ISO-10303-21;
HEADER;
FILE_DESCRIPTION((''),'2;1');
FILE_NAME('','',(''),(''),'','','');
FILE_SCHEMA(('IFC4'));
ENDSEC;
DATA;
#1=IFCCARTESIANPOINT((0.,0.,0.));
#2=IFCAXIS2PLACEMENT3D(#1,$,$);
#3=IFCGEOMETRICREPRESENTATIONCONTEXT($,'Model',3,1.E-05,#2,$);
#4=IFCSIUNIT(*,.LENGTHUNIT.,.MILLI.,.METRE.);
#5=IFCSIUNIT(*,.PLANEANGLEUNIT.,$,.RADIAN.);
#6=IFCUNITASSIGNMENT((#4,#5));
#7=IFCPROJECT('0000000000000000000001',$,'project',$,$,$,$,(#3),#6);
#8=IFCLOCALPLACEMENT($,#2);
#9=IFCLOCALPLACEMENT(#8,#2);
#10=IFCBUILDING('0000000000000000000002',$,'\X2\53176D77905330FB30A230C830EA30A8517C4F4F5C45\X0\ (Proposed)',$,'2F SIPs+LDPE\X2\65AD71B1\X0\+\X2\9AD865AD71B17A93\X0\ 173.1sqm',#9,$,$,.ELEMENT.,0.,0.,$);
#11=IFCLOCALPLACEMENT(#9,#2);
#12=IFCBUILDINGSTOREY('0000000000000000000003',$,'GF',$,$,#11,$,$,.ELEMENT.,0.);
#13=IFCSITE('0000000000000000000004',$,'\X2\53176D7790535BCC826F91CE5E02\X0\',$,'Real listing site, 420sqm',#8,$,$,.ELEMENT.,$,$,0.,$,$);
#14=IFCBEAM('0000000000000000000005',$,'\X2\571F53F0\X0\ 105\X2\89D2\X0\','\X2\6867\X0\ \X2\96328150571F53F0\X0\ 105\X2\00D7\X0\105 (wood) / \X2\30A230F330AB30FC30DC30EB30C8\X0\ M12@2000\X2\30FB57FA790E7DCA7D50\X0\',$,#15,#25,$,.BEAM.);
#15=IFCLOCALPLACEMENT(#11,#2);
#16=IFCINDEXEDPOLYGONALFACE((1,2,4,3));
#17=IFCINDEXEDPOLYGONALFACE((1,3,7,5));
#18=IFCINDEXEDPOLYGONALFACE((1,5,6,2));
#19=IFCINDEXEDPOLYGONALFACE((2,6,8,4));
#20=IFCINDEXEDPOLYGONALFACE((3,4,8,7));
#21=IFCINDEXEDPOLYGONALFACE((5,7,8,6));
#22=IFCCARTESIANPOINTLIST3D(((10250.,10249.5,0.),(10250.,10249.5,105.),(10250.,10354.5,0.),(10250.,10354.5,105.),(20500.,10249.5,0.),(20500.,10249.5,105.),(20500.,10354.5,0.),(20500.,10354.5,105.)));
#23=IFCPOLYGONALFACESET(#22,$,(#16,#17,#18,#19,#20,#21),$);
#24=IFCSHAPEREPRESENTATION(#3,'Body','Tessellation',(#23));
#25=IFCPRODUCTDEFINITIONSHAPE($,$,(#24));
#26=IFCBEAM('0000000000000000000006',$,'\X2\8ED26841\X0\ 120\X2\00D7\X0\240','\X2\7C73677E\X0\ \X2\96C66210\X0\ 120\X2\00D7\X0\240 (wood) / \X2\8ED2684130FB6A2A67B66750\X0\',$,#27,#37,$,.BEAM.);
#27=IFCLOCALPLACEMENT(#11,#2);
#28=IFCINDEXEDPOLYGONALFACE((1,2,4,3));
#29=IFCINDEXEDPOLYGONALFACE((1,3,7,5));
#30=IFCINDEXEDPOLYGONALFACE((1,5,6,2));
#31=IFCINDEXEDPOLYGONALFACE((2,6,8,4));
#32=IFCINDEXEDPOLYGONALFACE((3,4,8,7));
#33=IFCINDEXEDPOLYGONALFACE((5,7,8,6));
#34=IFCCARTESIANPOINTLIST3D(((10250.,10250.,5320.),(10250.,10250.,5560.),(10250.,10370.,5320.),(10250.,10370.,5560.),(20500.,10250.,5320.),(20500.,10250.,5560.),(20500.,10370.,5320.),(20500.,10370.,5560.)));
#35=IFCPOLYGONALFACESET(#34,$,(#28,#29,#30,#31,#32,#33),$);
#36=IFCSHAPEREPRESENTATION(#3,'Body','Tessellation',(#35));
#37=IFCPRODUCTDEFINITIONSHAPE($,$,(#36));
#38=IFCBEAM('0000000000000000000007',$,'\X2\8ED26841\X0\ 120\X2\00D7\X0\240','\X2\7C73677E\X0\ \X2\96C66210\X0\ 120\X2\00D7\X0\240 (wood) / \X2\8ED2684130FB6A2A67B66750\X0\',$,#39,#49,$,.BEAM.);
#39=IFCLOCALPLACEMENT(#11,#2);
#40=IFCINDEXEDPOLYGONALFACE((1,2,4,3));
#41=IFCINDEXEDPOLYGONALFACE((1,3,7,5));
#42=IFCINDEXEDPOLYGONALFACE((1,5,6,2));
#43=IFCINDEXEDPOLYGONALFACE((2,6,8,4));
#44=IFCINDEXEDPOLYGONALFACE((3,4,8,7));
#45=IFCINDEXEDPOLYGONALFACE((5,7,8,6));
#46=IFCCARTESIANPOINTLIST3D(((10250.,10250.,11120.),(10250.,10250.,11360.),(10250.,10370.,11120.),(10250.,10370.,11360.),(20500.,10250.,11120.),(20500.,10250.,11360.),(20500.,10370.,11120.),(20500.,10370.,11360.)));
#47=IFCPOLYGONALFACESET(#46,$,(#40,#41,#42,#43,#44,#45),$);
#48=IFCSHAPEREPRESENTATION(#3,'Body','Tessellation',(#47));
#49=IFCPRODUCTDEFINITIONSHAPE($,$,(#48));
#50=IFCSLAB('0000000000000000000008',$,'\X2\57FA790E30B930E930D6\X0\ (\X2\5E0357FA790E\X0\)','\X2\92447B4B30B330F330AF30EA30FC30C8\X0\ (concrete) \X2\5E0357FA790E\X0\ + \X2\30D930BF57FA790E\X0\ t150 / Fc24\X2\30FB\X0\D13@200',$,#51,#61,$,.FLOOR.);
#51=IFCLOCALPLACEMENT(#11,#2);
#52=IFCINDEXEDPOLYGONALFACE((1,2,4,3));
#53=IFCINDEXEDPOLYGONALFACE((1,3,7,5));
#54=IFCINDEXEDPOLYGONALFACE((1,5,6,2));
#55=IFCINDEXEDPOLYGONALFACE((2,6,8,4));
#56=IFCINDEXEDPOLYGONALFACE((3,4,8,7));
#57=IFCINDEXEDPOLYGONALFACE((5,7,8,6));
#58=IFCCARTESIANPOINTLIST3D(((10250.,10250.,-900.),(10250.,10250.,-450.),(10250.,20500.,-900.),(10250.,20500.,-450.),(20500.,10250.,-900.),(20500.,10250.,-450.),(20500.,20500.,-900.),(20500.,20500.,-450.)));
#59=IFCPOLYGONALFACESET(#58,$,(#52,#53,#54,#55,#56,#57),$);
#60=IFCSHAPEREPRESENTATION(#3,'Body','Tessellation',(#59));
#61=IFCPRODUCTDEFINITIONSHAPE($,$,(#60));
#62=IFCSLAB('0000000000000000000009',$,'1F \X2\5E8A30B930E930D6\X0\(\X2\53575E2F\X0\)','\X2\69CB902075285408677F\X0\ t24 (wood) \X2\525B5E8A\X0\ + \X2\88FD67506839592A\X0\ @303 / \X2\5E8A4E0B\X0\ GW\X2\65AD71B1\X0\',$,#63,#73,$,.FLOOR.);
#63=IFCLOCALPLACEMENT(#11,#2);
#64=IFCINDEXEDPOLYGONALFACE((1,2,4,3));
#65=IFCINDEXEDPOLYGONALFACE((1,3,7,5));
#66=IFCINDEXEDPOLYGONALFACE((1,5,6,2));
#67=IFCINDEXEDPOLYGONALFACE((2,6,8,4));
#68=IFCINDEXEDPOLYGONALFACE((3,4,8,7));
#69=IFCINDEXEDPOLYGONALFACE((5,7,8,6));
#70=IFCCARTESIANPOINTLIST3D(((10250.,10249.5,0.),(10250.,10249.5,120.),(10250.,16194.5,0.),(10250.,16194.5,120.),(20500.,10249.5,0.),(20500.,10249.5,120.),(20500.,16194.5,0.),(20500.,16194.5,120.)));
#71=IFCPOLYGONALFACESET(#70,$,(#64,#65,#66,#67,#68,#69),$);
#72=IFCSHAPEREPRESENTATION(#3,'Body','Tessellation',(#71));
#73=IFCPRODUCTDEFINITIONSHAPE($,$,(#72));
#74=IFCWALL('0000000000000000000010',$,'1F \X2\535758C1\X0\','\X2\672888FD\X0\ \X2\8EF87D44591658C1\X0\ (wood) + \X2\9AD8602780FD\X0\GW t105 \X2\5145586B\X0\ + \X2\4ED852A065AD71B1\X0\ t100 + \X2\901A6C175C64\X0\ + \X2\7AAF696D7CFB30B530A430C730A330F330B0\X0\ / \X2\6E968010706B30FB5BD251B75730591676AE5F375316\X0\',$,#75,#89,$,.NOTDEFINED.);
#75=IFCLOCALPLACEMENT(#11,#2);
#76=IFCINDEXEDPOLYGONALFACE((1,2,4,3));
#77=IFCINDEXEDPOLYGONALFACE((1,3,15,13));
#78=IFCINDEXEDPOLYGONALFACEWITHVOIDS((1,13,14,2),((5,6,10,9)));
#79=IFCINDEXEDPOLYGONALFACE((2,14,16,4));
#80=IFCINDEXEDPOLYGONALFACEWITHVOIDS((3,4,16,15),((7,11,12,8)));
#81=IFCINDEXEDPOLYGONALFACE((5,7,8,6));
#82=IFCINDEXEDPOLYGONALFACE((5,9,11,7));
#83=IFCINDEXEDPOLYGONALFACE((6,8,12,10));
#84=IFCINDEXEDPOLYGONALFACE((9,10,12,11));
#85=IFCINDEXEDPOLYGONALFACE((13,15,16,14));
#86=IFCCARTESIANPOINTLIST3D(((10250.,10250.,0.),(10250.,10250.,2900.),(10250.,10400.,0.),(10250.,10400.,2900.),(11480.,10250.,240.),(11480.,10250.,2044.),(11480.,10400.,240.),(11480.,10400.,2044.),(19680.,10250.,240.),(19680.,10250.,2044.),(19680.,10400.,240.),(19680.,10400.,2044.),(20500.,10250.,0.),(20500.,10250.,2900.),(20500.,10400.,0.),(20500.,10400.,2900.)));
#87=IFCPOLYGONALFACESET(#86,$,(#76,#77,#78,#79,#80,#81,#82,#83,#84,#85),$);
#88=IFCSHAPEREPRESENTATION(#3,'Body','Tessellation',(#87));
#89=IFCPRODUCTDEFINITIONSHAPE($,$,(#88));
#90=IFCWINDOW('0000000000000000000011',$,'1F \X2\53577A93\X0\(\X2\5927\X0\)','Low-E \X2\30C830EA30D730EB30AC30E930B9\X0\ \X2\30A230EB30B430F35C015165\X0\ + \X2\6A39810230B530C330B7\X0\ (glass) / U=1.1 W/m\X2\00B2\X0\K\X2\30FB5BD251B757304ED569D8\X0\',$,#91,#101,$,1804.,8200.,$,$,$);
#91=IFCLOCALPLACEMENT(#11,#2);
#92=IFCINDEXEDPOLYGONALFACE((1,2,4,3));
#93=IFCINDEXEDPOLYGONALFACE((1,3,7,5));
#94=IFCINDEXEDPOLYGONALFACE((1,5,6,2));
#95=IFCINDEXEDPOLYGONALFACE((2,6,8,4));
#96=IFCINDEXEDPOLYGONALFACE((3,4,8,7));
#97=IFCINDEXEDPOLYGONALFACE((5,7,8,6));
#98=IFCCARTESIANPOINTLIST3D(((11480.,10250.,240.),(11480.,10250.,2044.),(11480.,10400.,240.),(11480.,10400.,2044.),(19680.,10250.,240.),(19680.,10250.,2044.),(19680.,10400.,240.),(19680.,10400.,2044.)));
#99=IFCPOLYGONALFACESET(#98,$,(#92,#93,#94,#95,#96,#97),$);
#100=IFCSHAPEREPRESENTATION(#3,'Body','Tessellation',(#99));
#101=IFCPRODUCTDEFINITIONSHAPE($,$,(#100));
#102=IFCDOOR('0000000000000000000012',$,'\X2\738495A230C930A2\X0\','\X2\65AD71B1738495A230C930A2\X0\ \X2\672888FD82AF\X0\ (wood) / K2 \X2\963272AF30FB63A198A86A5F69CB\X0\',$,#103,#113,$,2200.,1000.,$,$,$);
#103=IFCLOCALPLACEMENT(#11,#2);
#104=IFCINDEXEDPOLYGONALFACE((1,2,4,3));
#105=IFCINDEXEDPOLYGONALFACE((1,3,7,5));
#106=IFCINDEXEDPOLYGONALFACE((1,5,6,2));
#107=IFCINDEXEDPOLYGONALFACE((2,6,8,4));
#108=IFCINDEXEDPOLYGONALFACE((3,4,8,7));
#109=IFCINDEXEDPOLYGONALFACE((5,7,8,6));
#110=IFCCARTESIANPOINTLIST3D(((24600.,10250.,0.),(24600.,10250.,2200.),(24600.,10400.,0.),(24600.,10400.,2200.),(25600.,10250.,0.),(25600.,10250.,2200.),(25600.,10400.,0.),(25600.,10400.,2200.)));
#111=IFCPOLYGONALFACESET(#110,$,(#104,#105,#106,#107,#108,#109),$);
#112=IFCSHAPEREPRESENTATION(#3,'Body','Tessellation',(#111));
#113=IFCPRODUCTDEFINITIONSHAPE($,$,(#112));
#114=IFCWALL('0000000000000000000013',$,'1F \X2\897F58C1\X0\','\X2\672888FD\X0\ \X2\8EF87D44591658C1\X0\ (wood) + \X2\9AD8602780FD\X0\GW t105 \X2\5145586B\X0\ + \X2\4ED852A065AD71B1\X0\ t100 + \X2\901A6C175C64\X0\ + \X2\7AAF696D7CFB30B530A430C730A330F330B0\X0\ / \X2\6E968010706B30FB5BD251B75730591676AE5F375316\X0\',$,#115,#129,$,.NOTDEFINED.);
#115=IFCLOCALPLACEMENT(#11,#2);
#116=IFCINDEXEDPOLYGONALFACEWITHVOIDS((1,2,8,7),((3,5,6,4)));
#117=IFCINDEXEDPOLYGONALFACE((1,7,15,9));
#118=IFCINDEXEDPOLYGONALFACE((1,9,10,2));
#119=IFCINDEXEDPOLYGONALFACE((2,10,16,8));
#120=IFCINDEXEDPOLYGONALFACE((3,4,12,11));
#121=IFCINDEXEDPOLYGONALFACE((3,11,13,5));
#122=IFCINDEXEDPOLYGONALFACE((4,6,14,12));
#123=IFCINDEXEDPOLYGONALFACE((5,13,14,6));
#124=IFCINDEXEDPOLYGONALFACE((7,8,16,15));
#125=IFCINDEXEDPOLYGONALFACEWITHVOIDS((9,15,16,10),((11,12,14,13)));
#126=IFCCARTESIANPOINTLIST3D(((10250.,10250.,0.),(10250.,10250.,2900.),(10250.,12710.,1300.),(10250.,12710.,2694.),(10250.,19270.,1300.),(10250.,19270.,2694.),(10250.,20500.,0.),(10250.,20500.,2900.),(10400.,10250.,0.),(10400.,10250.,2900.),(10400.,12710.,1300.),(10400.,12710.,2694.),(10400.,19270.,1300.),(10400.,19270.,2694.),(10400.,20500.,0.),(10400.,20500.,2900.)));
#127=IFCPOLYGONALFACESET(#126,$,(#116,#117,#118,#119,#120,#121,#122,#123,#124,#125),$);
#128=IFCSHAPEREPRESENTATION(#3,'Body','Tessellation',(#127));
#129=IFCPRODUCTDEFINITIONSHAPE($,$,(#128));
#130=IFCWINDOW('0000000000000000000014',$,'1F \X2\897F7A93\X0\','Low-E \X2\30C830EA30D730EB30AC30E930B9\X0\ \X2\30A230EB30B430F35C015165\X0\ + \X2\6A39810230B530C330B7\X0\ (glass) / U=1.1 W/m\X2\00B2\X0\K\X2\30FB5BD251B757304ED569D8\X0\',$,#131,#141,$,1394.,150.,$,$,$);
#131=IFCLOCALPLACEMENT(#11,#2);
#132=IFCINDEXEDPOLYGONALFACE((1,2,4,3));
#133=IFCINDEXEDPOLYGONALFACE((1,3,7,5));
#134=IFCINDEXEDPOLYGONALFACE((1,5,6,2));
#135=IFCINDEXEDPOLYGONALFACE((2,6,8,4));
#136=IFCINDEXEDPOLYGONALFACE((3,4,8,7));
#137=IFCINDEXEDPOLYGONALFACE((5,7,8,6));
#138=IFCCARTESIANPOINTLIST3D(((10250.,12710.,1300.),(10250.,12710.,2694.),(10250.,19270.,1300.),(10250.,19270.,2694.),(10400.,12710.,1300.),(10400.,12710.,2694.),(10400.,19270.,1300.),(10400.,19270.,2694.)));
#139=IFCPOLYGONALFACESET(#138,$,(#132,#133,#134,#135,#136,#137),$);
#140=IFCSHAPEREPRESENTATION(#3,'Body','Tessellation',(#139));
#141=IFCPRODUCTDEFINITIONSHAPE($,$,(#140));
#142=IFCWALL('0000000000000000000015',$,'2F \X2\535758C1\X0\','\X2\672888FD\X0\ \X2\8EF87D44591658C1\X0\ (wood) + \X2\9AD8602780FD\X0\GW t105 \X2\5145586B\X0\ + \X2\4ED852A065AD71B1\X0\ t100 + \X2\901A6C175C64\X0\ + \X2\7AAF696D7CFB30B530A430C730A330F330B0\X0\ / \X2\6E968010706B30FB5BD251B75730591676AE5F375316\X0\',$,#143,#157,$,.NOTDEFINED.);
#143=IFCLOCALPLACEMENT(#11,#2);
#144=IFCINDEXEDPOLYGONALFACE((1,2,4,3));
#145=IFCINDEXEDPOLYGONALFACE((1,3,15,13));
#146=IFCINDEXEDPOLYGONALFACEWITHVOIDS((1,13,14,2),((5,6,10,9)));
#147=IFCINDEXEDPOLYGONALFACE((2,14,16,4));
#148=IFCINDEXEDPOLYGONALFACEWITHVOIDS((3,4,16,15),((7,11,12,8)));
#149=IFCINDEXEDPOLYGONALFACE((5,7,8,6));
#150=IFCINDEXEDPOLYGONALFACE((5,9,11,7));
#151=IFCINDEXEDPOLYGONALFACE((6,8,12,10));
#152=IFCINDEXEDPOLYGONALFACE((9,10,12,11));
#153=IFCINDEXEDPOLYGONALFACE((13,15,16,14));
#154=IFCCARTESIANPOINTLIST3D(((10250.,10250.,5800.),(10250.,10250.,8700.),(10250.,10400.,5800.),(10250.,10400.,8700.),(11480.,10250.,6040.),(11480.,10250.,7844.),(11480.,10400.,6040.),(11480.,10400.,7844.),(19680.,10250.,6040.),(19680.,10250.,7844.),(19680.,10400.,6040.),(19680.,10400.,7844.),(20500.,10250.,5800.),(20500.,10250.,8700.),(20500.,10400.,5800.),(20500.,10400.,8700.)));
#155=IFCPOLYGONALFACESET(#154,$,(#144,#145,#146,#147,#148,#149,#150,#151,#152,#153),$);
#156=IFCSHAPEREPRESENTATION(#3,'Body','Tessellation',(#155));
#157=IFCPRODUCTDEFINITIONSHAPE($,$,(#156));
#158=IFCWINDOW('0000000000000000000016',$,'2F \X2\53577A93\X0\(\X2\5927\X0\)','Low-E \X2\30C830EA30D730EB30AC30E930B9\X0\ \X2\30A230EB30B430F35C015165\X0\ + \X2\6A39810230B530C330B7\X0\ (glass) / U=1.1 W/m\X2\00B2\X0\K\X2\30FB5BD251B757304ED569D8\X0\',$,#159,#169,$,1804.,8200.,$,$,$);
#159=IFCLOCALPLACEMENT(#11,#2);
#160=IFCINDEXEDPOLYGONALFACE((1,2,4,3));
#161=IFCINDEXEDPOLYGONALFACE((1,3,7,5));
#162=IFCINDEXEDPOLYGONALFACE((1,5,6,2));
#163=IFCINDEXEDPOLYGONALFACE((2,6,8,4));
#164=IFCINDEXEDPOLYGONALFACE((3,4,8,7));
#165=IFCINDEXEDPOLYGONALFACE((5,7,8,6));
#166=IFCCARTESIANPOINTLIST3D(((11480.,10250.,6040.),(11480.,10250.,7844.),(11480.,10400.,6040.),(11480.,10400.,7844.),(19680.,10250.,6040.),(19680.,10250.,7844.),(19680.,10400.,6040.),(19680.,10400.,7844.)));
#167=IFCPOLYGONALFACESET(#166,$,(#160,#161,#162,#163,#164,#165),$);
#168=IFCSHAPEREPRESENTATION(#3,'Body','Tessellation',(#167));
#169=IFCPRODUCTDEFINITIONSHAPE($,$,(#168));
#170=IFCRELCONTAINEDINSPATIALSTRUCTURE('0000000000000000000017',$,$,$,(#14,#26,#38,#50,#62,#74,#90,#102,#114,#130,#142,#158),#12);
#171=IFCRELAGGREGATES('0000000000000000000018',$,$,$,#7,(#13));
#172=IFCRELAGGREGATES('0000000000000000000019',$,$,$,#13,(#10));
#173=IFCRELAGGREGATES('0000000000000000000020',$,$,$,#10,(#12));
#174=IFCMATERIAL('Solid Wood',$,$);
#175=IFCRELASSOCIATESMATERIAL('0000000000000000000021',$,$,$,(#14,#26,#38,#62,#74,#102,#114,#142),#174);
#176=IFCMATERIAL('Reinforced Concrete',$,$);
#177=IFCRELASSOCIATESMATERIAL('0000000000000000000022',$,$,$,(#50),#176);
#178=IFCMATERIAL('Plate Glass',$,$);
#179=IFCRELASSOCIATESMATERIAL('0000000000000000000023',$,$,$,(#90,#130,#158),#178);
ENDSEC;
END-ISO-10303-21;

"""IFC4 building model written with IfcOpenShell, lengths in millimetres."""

from ifc_helpers import new_model, si_unit, frame, frame_2d, origin, place, context, project, spatial, rectangle, extrude, material, element, fill, save


model = new_model("IFC4")

# Units and contexts
model_context = context("Model", 3, precision=1e-05, world=origin())
ifc_project = project(units=[si_unit("LENGTHUNIT", "METRE", prefix="MILLI"), si_unit("PLANEANGLEUNIT", "RADIAN")], contexts=[model_context])

# Site, building, storey
site_placement = place(None, origin())
site = spatial("IfcSite", under=ifc_project, at=site_placement, Name="北海道富良野市", ObjectType="Real listing site, 420sqm", CompositionType="ELEMENT", RefElevation=0.0)
building_placement = place(site_placement, origin())
building = spatial("IfcBuilding", under=site, at=building_placement, Name="北海道・アトリエ兼住居 (Proposed)", ObjectType="2F SIPs+LDPE断熱+高断熱窓 173.1sqm", CompositionType="ELEMENT", ElevationOfRefHeight=0.0, ElevationOfTerrain=0.0)
storey_placement = place(building_placement, origin())
storey = spatial("IfcBuildingStorey", under=building, at=storey_placement, Name="GF", CompositionType="ELEMENT", Elevation=0.0)

# Shared definitions
ifc_material_1 = material(Name="Solid Wood")

# Beams
beam_1_placement = place(storey_placement, frame((5125.0, 5125.0, 0.0)))
element("IfcBeam", 1, at=beam_1_placement, inside=storey, material=ifc_material_1, Name="土台 105角", Description="桧 防腐土台 105×105 (wood) / アンカーボルト M12@2000・基礎緊結", PredefinedType="BEAM", context=model_context, shape_type="SweptSolid", body=[
    extrude(rectangle(XDim=10250.0, YDim=105.0, at=frame_2d((5125.0, 52.0))), frame((5125.0, 5125.0, 0.0)), (0.0, 0.0, 1.0), 105.0),
])
beam_2_placement = place(storey_placement, frame((5125.0, 5125.0, 2660.0)))
element("IfcBeam", 2, at=beam_2_placement, inside=storey, material=ifc_material_1, Name="軒桁 120×240", Description="米松 集成 120×240 (wood) / 軒桁・横架材", PredefinedType="BEAM", context=model_context, shape_type="SweptSolid", body=[
    extrude(rectangle(XDim=10250.0, YDim=120.0, at=frame_2d((5125.0, 60.0))), frame((5125.0, 5125.0, 2660.0)), (0.0, 0.0, 1.0), 240.0),
])
beam_3_placement = place(storey_placement, frame((5125.0, 5125.0, 5560.0)))
element("IfcBeam", 3, at=beam_3_placement, inside=storey, material=ifc_material_1, Name="軒桁 120×240", Description="米松 集成 120×240 (wood) / 軒桁・横架材", PredefinedType="BEAM", context=model_context, shape_type="SweptSolid", body=[
    extrude(rectangle(XDim=10250.0, YDim=120.0, at=frame_2d((5125.0, 60.0))), frame((5125.0, 5125.0, 5560.0)), (0.0, 0.0, 1.0), 240.0),
])

# Slabs
ifc_material_2 = material(Name="Reinforced Concrete")
slab_1_placement = place(storey_placement, frame((5125.0, 5125.0, -450.0)))
element("IfcSlab", 4, at=slab_1_placement, inside=storey, material=ifc_material_2, Name="基礎スラブ (布基礎)", Description="鉄筋コンクリート (concrete) 布基礎 + ベタ基礎 t150 / Fc24・D13@200", PredefinedType="FLOOR", context=model_context, shape_type="SweptSolid", body=[
    extrude(rectangle(XDim=10250.0, YDim=10250.0, at=frame_2d((5125.0, 5125.0))), frame((5125.0, 5125.0, -450.0)), (0.0, 0.0, 1.0), 450.0),
])
slab_2_placement = place(storey_placement, frame((5125.0, 5125.0, 0.0)))
element("IfcSlab", 5, at=slab_2_placement, inside=storey, material=ifc_material_1, Name="1F 床スラブ(南帯)", Description="構造用合板 t24 (wood) 剛床 + 製材根太 @303 / 床下 GW断熱", PredefinedType="FLOOR", context=model_context, shape_type="SweptSolid", body=[
    extrude(rectangle(XDim=10250.0, YDim=5945.0, at=frame_2d((5125.0, 2972.0))), frame((5125.0, 5125.0, 0.0)), (0.0, 0.0, 1.0), 120.0),
])

# Wall, openings, window, door
wall_1_placement = place(storey_placement, frame((5125.0, 5125.0, 0.0)))
wall_1 = element("IfcWall", 6, at=wall_1_placement, inside=storey, material=ifc_material_1, Name="1F 南壁", Description="木製 軸組外壁 (wood) + 高性能GW t105 充填 + 付加断熱 t100 + 通気層 + 窯業系サイディング / 準耐火・寒冷地外皮強化", PredefinedType="NOTDEFINED", context=model_context, shape_type="SweptSolid", body=[
    extrude(rectangle(XDim=10250.0, YDim=150.0, at=frame_2d((5125.0, 75.0))), frame((5125.0, 5125.0, 0.0)), (0.0, 0.0, 1.0), 2900.0),
])
opening_1_placement = place(storey_placement, frame((5740.0, 5125.0, 120.0)))
opening_1 = element("IfcOpeningElement", 7, at=opening_1_placement, cuts=wall_1, PredefinedType="NOTDEFINED", context=model_context, shape_type="SweptSolid", body=[
    extrude(rectangle(XDim=8200.0, YDim=150.0, at=frame_2d((4100.0, 75.0))), frame((5740.0, 5125.0, 120.0)), (0.0, 0.0, 1.0), 1804.0),
])
opening_2_placement = place(storey_placement, frame((12300.0, 5125.0, 0.0)))
opening_2 = element("IfcOpeningElement", 8, at=opening_2_placement, cuts=wall_1, PredefinedType="NOTDEFINED", context=model_context, shape_type="SweptSolid", body=[
    extrude(rectangle(XDim=1000.0, YDim=150.0, at=frame_2d((500.0, 75.0))), frame((12300.0, 5125.0, 0.0)), (0.0, 0.0, 1.0), 2200.0),
])
ifc_material_3 = material(Name="Plate Glass")
window_1_placement = place(storey_placement, frame((5740.0, 5125.0, 120.0)))
window_1 = element("IfcWindow", 9, at=window_1_placement, inside=storey, material=ifc_material_3, Name="1F 南窓(大)", Description="Low-E トリプルガラス アルゴン封入 + 樹脂サッシ (glass) / U=1.1 W/m²K・寒冷地仕様", OverallHeight=1804.0, OverallWidth=8200.0, context=model_context, shape_type="SweptSolid", body=[
    extrude(rectangle(XDim=8200.0, YDim=150.0, at=frame_2d((4100.0, 75.0))), frame((5740.0, 5125.0, 120.0)), (0.0, 0.0, 1.0), 1804.0),
])
fill(opening_1, window_1)
door_placement = place(storey_placement, frame((12300.0, 5125.0, 0.0)))
door = element("IfcDoor", 10, at=door_placement, inside=storey, material=ifc_material_1, Name="玄関ドア", Description="断熱玄関ドア 木製芯 (wood) / K2 防犯・採風機構", OverallHeight=2200.0, OverallWidth=1000.0, context=model_context, shape_type="SweptSolid", body=[
    extrude(rectangle(XDim=1000.0, YDim=150.0, at=frame_2d((500.0, 75.0))), frame((12300.0, 5125.0, 0.0)), (0.0, 0.0, 1.0), 2200.0),
])
fill(opening_2, door)

# Walls, openings, windows
wall_2_placement = place(storey_placement, frame((5125.0, 5125.0, 0.0)))
wall_2 = element("IfcWall", 11, at=wall_2_placement, inside=storey, material=ifc_material_1, Name="1F 西壁", Description="木製 軸組外壁 (wood) + 高性能GW t105 充填 + 付加断熱 t100 + 通気層 + 窯業系サイディング / 準耐火・寒冷地外皮強化", PredefinedType="NOTDEFINED", context=model_context, shape_type="SweptSolid", body=[
    extrude(rectangle(XDim=150.0, YDim=10250.0, at=frame_2d((75.0, 5125.0))), frame((5125.0, 5125.0, 0.0)), (0.0, 0.0, 1.0), 2900.0),
])
opening_3_placement = place(storey_placement, frame((5125.0, 6355.0, 650.0)))
opening_3 = element("IfcOpeningElement", 12, at=opening_3_placement, cuts=wall_2, PredefinedType="NOTDEFINED", context=model_context, shape_type="SweptSolid", body=[
    extrude(rectangle(XDim=150.0, YDim=6560.0, at=frame_2d((75.0, 3280.0))), frame((5125.0, 6355.0, 650.0)), (0.0, 0.0, 1.0), 1394.0),
])
window_2_placement = place(storey_placement, frame((5125.0, 6355.0, 650.0)))
window_2 = element("IfcWindow", 13, at=window_2_placement, inside=storey, material=ifc_material_3, Name="1F 西窓", Description="Low-E トリプルガラス アルゴン封入 + 樹脂サッシ (glass) / U=1.1 W/m²K・寒冷地仕様", OverallHeight=1394.0, OverallWidth=150.0, context=model_context, shape_type="SweptSolid", body=[
    extrude(rectangle(XDim=150.0, YDim=6560.0, at=frame_2d((75.0, 3280.0))), frame((5125.0, 6355.0, 650.0)), (0.0, 0.0, 1.0), 1394.0),
])
fill(opening_3, window_2)
wall_3_placement = place(storey_placement, frame((5125.0, 5125.0, 2900.0)))
wall_3 = element("IfcWall", 14, at=wall_3_placement, inside=storey, material=ifc_material_1, Name="2F 南壁", Description="木製 軸組外壁 (wood) + 高性能GW t105 充填 + 付加断熱 t100 + 通気層 + 窯業系サイディング / 準耐火・寒冷地外皮強化", PredefinedType="NOTDEFINED", context=model_context, shape_type="SweptSolid", body=[
    extrude(rectangle(XDim=10250.0, YDim=150.0, at=frame_2d((5125.0, 75.0))), frame((5125.0, 5125.0, 2900.0)), (0.0, 0.0, 1.0), 2900.0),
])
opening_4_placement = place(storey_placement, frame((5740.0, 5125.0, 3020.0)))
opening_4 = element("IfcOpeningElement", 15, at=opening_4_placement, cuts=wall_3, PredefinedType="NOTDEFINED", context=model_context, shape_type="SweptSolid", body=[
    extrude(rectangle(XDim=8200.0, YDim=150.0, at=frame_2d((4100.0, 75.0))), frame((5740.0, 5125.0, 3020.0)), (0.0, 0.0, 1.0), 1804.0),
])
window_3_placement = place(storey_placement, frame((5740.0, 5125.0, 3020.0)))
window_3 = element("IfcWindow", 16, at=window_3_placement, inside=storey, material=ifc_material_3, Name="2F 南窓(大)", Description="Low-E トリプルガラス アルゴン封入 + 樹脂サッシ (glass) / U=1.1 W/m²K・寒冷地仕様", OverallHeight=1804.0, OverallWidth=8200.0, context=model_context, shape_type="SweptSolid", body=[
    extrude(rectangle(XDim=8200.0, YDim=150.0, at=frame_2d((4100.0, 75.0))), frame((5740.0, 5125.0, 3020.0)), (0.0, 0.0, 1.0), 1804.0),
])
fill(opening_4, window_3)

save(model, "model.ifc")
